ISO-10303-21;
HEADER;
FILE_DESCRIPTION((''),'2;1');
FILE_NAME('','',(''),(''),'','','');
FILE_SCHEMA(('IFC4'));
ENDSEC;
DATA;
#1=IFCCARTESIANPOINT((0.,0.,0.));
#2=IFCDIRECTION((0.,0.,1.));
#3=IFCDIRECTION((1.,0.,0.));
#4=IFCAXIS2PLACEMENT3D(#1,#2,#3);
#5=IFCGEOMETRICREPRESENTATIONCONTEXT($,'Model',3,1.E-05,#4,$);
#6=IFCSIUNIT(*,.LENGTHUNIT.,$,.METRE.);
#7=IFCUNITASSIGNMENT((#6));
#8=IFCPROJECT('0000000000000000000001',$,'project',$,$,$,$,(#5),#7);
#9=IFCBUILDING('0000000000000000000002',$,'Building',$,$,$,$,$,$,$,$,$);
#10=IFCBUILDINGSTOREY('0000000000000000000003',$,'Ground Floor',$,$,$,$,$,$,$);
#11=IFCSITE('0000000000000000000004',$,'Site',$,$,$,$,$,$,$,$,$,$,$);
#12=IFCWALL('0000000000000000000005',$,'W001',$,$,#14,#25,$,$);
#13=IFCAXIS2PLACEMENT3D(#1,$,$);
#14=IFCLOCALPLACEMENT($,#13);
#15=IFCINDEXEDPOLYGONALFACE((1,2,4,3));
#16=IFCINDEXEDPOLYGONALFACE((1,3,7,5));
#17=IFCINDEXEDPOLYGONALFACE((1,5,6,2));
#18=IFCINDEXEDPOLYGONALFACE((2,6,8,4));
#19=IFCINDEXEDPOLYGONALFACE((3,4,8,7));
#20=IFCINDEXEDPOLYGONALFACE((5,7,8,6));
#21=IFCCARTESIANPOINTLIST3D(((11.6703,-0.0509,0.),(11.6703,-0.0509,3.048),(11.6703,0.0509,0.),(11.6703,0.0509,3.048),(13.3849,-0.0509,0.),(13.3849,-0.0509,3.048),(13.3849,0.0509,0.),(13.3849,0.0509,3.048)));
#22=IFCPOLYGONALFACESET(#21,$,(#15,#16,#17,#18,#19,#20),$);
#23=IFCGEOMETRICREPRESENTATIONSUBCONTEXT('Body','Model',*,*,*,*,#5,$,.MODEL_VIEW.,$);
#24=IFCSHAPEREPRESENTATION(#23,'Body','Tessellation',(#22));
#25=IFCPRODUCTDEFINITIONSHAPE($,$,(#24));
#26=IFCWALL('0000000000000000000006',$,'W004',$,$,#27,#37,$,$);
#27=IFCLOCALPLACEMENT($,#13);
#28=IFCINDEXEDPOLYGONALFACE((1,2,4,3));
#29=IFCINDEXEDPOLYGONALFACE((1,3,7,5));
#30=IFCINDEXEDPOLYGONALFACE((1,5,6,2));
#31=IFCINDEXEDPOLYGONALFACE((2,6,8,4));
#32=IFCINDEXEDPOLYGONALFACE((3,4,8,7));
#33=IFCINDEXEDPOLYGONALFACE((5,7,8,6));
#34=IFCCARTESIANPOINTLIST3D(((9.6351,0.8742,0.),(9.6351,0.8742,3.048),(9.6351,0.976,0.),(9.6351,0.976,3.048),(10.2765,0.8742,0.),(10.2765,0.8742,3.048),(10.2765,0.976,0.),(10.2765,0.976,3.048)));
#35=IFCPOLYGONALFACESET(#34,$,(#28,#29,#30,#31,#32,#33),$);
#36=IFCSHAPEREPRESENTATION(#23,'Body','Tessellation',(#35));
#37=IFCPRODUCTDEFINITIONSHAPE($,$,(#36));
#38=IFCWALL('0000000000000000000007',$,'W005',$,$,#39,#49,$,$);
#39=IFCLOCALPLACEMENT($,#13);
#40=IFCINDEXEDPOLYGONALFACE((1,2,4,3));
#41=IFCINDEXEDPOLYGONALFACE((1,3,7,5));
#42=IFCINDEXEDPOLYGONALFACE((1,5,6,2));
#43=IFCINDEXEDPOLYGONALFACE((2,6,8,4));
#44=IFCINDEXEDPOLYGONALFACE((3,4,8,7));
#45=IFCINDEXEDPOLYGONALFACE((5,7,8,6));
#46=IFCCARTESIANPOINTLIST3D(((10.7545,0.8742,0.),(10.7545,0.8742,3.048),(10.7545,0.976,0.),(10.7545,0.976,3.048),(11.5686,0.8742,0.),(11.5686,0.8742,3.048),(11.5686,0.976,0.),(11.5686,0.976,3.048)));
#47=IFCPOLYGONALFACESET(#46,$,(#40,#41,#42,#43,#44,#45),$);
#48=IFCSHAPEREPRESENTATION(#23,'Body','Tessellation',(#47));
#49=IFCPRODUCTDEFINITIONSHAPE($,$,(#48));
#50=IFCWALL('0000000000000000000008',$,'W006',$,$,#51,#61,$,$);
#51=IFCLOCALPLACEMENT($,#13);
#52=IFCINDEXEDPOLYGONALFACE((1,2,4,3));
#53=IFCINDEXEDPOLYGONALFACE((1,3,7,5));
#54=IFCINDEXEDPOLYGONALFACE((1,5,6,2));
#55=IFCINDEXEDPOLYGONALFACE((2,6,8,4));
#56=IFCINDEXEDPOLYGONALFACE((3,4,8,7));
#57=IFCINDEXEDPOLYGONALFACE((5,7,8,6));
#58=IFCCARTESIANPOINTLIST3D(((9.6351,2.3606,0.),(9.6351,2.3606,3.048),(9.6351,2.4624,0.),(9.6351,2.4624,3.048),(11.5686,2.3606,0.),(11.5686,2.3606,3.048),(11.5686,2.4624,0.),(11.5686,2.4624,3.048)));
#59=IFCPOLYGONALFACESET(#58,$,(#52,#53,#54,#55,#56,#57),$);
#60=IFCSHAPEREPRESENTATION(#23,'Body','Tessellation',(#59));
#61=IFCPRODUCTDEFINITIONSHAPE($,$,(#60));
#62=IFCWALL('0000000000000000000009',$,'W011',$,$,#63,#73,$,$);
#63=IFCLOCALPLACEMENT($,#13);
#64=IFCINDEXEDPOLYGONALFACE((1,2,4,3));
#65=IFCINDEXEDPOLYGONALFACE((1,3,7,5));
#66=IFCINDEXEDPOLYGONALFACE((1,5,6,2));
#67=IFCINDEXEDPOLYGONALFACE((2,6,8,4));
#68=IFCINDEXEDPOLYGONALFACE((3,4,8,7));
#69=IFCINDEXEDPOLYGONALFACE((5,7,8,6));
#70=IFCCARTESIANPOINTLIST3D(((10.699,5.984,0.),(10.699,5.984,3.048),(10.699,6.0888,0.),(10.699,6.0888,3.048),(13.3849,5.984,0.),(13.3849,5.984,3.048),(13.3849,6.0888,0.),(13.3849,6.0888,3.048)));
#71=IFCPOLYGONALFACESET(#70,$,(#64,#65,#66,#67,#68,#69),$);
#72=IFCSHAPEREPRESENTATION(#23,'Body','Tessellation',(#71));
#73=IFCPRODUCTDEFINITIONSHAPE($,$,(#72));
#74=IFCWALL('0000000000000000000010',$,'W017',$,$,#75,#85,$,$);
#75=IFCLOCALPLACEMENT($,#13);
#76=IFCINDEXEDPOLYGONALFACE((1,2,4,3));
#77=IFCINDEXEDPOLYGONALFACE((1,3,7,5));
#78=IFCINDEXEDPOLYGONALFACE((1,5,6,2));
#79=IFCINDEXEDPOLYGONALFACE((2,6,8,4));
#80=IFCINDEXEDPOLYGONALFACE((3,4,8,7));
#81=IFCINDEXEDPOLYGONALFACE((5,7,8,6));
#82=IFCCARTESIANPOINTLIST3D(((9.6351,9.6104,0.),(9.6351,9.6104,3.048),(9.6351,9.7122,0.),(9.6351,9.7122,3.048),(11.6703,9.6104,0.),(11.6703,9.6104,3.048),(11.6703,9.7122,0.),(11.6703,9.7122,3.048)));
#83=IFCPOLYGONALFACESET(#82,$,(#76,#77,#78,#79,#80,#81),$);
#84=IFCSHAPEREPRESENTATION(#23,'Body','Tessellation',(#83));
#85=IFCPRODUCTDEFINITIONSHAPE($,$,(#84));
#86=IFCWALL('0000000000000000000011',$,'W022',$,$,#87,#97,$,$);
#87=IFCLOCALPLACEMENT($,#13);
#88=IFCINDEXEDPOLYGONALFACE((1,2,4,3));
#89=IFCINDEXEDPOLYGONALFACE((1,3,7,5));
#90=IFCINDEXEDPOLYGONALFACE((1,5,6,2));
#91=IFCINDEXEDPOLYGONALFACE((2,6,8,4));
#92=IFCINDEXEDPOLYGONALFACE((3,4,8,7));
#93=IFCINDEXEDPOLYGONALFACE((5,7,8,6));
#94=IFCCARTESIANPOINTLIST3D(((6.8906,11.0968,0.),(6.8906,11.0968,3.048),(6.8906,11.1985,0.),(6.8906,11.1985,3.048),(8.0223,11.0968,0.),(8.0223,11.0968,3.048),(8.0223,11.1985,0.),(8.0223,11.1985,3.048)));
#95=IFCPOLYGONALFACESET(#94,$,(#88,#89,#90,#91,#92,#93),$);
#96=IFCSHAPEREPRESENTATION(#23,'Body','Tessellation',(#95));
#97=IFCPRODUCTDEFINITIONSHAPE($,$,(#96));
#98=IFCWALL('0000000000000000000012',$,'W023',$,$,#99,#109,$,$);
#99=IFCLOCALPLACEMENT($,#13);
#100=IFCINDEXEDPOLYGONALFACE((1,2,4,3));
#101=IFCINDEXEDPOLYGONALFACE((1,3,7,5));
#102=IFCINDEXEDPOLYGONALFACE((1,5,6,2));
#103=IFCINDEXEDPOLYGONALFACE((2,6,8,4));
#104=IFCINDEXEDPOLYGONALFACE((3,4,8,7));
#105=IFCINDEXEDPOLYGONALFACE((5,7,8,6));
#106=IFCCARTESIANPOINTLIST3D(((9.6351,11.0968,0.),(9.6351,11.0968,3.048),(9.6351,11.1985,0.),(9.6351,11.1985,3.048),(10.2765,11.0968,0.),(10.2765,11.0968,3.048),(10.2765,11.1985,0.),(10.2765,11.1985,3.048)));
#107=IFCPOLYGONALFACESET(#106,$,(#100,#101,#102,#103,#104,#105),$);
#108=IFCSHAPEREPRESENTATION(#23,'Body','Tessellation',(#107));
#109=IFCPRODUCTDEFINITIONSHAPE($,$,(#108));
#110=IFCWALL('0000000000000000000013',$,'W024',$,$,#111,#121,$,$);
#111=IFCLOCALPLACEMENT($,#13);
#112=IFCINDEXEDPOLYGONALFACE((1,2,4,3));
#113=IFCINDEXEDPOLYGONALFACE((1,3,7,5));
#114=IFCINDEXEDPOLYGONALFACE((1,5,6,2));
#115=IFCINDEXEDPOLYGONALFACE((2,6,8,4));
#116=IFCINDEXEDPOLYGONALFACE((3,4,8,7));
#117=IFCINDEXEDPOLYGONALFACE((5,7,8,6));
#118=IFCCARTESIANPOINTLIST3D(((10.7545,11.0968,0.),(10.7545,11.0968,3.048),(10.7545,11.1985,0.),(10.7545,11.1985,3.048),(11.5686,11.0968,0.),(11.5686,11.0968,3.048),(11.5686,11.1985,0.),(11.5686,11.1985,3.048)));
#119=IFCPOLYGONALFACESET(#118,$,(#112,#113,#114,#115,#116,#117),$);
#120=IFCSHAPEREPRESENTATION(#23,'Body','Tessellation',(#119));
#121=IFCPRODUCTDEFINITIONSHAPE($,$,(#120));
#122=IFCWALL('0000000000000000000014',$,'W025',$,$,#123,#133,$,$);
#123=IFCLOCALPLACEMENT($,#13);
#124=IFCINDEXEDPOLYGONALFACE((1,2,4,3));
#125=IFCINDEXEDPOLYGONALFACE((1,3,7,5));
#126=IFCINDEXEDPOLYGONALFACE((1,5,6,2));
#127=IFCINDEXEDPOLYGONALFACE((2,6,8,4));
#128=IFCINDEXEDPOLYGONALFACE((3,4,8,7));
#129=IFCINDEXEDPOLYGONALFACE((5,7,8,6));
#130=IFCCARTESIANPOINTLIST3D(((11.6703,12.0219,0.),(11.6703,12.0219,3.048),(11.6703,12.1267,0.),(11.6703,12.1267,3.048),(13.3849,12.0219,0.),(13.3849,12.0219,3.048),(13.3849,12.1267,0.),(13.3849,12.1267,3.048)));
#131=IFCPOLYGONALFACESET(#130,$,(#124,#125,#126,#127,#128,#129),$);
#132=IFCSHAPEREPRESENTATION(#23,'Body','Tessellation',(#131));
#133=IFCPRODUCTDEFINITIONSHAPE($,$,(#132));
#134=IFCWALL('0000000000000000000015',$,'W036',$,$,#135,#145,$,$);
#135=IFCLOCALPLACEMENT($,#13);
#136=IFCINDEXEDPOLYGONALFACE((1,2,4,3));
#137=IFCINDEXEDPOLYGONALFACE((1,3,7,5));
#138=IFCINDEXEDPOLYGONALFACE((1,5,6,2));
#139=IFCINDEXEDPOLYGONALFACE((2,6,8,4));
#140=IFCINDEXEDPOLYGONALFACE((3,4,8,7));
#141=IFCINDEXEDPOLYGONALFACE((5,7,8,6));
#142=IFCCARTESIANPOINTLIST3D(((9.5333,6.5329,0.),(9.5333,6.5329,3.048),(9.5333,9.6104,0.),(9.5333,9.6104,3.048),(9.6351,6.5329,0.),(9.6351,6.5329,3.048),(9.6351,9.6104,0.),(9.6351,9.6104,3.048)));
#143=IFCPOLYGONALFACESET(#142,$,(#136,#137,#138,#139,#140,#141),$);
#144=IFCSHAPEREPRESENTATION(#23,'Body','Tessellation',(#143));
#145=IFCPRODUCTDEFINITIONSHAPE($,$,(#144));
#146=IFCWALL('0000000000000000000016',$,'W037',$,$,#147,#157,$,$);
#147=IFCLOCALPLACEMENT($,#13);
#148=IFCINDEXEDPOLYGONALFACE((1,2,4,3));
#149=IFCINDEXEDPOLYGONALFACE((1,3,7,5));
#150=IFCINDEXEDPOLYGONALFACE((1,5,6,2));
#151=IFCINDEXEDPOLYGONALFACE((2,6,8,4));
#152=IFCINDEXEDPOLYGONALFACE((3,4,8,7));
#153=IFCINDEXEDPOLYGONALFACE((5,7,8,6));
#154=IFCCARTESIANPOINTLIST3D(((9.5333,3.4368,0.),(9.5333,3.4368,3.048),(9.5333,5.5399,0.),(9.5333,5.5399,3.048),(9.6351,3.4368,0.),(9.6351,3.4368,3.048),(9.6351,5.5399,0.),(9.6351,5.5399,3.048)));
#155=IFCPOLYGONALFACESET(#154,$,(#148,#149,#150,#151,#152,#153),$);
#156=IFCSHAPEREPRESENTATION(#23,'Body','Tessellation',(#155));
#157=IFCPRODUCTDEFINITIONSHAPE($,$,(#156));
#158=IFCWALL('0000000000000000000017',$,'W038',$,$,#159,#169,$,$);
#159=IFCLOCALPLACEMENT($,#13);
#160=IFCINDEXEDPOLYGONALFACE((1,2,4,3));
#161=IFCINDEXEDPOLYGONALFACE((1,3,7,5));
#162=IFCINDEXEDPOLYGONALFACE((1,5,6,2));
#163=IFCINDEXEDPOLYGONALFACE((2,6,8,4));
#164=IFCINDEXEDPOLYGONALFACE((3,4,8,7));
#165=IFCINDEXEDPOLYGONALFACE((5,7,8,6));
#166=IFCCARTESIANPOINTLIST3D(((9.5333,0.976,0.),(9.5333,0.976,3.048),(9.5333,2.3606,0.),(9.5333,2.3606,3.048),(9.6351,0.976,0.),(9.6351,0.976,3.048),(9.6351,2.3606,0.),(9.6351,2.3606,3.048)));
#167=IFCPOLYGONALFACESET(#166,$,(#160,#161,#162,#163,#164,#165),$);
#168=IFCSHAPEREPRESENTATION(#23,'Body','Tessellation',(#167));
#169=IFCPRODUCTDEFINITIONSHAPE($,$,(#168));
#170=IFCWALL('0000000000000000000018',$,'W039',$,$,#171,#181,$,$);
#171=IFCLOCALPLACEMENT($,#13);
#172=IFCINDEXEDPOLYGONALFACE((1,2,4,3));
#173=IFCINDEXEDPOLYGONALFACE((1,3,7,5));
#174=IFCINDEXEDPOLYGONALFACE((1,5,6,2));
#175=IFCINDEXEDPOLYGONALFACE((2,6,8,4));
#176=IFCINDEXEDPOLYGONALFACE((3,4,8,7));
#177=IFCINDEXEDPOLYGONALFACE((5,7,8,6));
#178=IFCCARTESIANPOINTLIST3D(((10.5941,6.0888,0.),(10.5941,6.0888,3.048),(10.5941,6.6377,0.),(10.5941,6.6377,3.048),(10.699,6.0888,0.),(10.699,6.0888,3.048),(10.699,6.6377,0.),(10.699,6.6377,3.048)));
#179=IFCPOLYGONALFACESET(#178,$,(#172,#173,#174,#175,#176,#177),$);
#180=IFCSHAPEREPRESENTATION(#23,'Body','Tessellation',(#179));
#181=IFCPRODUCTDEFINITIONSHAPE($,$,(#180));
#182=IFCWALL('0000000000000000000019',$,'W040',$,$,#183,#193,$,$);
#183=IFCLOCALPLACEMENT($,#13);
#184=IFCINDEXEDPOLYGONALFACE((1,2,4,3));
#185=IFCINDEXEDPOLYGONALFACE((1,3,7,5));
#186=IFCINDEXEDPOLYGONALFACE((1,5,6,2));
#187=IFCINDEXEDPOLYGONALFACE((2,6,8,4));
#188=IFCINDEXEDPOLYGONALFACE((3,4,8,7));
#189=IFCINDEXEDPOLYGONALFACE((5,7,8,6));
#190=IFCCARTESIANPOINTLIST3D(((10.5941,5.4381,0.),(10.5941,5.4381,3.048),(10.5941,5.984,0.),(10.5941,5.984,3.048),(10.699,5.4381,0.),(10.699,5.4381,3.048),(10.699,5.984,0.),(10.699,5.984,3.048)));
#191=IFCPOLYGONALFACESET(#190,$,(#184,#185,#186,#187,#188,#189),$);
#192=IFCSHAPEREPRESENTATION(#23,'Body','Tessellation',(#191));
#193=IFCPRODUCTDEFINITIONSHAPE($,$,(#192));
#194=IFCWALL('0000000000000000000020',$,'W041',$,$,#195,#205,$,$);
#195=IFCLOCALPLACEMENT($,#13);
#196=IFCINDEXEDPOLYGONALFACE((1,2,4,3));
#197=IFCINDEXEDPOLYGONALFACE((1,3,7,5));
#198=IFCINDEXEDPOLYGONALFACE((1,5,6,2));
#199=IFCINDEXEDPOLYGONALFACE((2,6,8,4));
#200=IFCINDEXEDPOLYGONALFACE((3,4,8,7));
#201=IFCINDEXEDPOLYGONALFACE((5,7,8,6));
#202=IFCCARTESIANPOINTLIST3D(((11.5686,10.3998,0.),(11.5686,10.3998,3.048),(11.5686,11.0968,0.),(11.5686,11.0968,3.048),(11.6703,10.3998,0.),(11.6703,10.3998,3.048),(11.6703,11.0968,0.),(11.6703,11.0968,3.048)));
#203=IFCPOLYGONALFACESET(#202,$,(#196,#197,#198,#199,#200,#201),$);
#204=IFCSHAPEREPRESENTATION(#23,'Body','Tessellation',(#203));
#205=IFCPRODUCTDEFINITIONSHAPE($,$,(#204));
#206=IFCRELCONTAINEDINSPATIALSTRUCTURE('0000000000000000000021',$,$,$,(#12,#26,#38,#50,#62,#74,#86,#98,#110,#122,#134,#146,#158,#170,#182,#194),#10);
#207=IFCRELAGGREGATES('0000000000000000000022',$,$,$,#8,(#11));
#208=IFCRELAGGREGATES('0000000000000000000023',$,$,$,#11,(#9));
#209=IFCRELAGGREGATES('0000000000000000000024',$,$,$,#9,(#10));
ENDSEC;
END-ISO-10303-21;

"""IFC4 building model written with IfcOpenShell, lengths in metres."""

from ifc_helpers import new_model, si_unit, frame, origin_with_axes, place, context, subcontext, project, spatial, line, indexed_curve, outline, extrude, element, save


model = new_model("IFC4")

# Units and contexts
model_context = context("Model", 3, precision=1e-05, world=origin_with_axes())
body_context = subcontext(model_context, "Body", "Model", "MODEL_VIEW")
ifc_project = project(units=[si_unit("LENGTHUNIT", "METRE")], contexts=[model_context])

# Site, building, storey
site = spatial("IfcSite", under=ifc_project, Name="Site")
building = spatial("IfcBuilding", under=site, Name="Building")
storey = spatial("IfcBuildingStorey", under=building, Name="Ground Floor")

# Walls
wall_1_placement = place(None, frame((11.6703, 0.0, 0.0), z_axis=(0.0, 0.0, 1.0), x_axis=(1.0, 0.0, 0.0)))
element("IfcWall", 1, at=wall_1_placement, inside=storey, Name="W001", context=body_context, shape_type="SweptSolid", body=[
    extrude(outline(indexed_curve([(0.0, -0.0509), (1.7145, -0.0509), (1.7145, 0.0509), (0.0, 0.0509)], segments=[line(1, 2, 3, 4, 1)])), origin_with_axes(), (0.0, 0.0, 1.0), 3.048),
])
wall_2_placement = place(None, frame((9.6351, 0.9251, 0.0), z_axis=(0.0, 0.0, 1.0), x_axis=(1.0, 0.0, 0.0)))
element("IfcWall", 2, at=wall_2_placement, inside=storey, Name="W004", context=body_context, shape_type="SweptSolid", body=[
    extrude(outline(indexed_curve([(0.0, -0.0509), (0.6414, -0.0509), (0.6414, 0.0509), (0.0, 0.0509)], segments=[line(1, 2, 3, 4, 1)])), origin_with_axes(), (0.0, 0.0, 1.0), 3.048),
])
wall_3_placement = place(None, frame((10.7545, 0.9251, 0.0), z_axis=(0.0, 0.0, 1.0), x_axis=(1.0, 0.0, 0.0)))
element("IfcWall", 3, at=wall_3_placement, inside=storey, Name="W005", context=body_context, shape_type="SweptSolid", body=[
    extrude(outline(indexed_curve([(0.0, -0.0509), (0.8141, -0.0509), (0.8141, 0.0509), (0.0, 0.0509)], segments=[line(1, 2, 3, 4, 1)])), origin_with_axes(), (0.0, 0.0, 1.0), 3.048),
])
wall_4_placement = place(None, frame((9.6351, 2.4115, 0.0), z_axis=(0.0, 0.0, 1.0), x_axis=(1.0, 0.0, 0.0)))
element("IfcWall", 4, at=wall_4_placement, inside=storey, Name="W006", context=body_context, shape_type="SweptSolid", body=[
    extrude(outline(indexed_curve([(0.0, -0.0509), (1.9335, -0.0509), (1.9335, 0.0509), (0.0, 0.0509)], segments=[line(1, 2, 3, 4, 1)])), origin_with_axes(), (0.0, 0.0, 1.0), 3.048),
])
for number, where, z_axis, x_axis, name in (
    (5, (10.699, 6.0364, 0.0), (0.0, 0.0, 1.0), (1.0, 0.0, 0.0), "W011"),
):
    element("IfcWall", number, at=place(None, frame(where, z_axis=z_axis, x_axis=x_axis)), inside=storey, Name=name, context=body_context, shape_type="SweptSolid", body=[
        extrude(outline(indexed_curve([(0.0, -0.0524), (2.6859, -0.0524), (2.6859, 0.0524), (0.0, 0.0524)], segments=[line(1, 2, 3, 4, 1)])), origin_with_axes(), (0.0, 0.0, 1.0), 3.048),
    ])
wall_5_placement = place(None, frame((9.6351, 9.6613, 0.0), z_axis=(0.0, 0.0, 1.0), x_axis=(1.0, 0.0, 0.0)))
element("IfcWall", 6, at=wall_5_placement, inside=storey, Name="W017", context=body_context, shape_type="SweptSolid", body=[
    extrude(outline(indexed_curve([(0.0, -0.0509), (2.0353, -0.0509), (2.0353, 0.0509), (0.0, 0.0509)], segments=[line(1, 2, 3, 4, 1)])), origin_with_axes(), (0.0, 0.0, 1.0), 3.048),
])
wall_6_placement = place(None, frame((6.8906, 11.1476, 0.0), z_axis=(0.0, 0.0, 1.0), x_axis=(1.0, 0.0, 0.0)))
element("IfcWall", 7, at=wall_6_placement, inside=storey, Name="W022", context=body_context, shape_type="SweptSolid", body=[
    extrude(outline(indexed_curve([(0.0, -0.0509), (1.1317, -0.0509), (1.1317, 0.0509), (0.0, 0.0509)], segments=[line(1, 2, 3, 4, 1)])), origin_with_axes(), (0.0, 0.0, 1.0), 3.048),
])
wall_7_placement = place(None, frame((9.6351, 11.1476, 0.0), z_axis=(0.0, 0.0, 1.0), x_axis=(1.0, 0.0, 0.0)))
element("IfcWall", 8, at=wall_7_placement, inside=storey, Name="W023", context=body_context, shape_type="SweptSolid", body=[
    extrude(outline(indexed_curve([(0.0, -0.0509), (0.6414, -0.0509), (0.6414, 0.0509), (0.0, 0.0509)], segments=[line(1, 2, 3, 4, 1)])), origin_with_axes(), (0.0, 0.0, 1.0), 3.048),
])
wall_8_placement = place(None, frame((10.7545, 11.1476, 0.0), z_axis=(0.0, 0.0, 1.0), x_axis=(1.0, 0.0, 0.0)))
element("IfcWall", 9, at=wall_8_placement, inside=storey, Name="W024", context=body_context, shape_type="SweptSolid", body=[
    extrude(outline(indexed_curve([(0.0, -0.0509), (0.8141, -0.0509), (0.8141, 0.0509), (0.0, 0.0509)], segments=[line(1, 2, 3, 4, 1)])), origin_with_axes(), (0.0, 0.0, 1.0), 3.048),
])
wall_9_placement = place(None, frame((11.6703, 12.0743, 0.0), z_axis=(0.0, 0.0, 1.0), x_axis=(1.0, 0.0, 0.0)))
element("IfcWall", 10, at=wall_9_placement, inside=storey, Name="W025", context=body_context, shape_type="SweptSolid", body=[
    extrude(outline(indexed_curve([(0.0, -0.0524), (1.7145, -0.0524), (1.7145, 0.0524), (0.0, 0.0524)], segments=[line(1, 2, 3, 4, 1)])), origin_with_axes(), (0.0, 0.0, 1.0), 3.048),
])
wall_10_placement = place(None, frame((9.5842, 6.5329, 0.0), z_axis=(0.0, 0.0, 1.0), x_axis=(0.0, 1.0, 0.0)))
element("IfcWall", 11, at=wall_10_placement, inside=storey, Name="W036", context=body_context, shape_type="SweptSolid", body=[
    extrude(outline(indexed_curve([(0.0, -0.0509), (3.0776, -0.0509), (3.0776, 0.0509), (0.0, 0.0509)], segments=[line(1, 2, 3, 4, 1)])), origin_with_axes(), (0.0, 0.0, 1.0), 3.048),
])
wall_11_placement = place(None, frame((9.5842, 3.4368, 0.0), z_axis=(0.0, 0.0, 1.0), x_axis=(0.0, 1.0, 0.0)))
element("IfcWall", 12, at=wall_11_placement, inside=storey, Name="W037", context=body_context, shape_type="SweptSolid", body=[
    extrude(outline(indexed_curve([(0.0, -0.0509), (2.1031, -0.0509), (2.1031, 0.0509), (0.0, 0.0509)], segments=[line(1, 2, 3, 4, 1)])), origin_with_axes(), (0.0, 0.0, 1.0), 3.048),
])
wall_12_placement = place(None, frame((9.5842, 0.976, 0.0), z_axis=(0.0, 0.0, 1.0), x_axis=(0.0, 1.0, 0.0)))
element("IfcWall", 13, at=wall_12_placement, inside=storey, Name="W038", context=body_context, shape_type="SweptSolid", body=[
    extrude(outline(indexed_curve([(0.0, -0.0509), (1.3846, -0.0509), (1.3846, 0.0509), (0.0, 0.0509)], segments=[line(1, 2, 3, 4, 1)])), origin_with_axes(), (0.0, 0.0, 1.0), 3.048),
])
wall_13_placement = place(None, frame((10.6465, 6.0888, 0.0), z_axis=(0.0, 0.0, 1.0), x_axis=(0.0, 1.0, 0.0)))
element("IfcWall", 14, at=wall_13_placement, inside=storey, Name="W039", context=body_context, shape_type="SweptSolid", body=[
    extrude(outline(indexed_curve([(0.0, -0.0524), (0.5489, -0.0524), (0.5489, 0.0524), (0.0, 0.0524)], segments=[line(1, 2, 3, 4, 1)])), origin_with_axes(), (0.0, 0.0, 1.0), 3.048),
])
wall_14_placement = place(None, frame((10.6465, 5.4381, 0.0), z_axis=(0.0, 0.0, 1.0), x_axis=(0.0, 1.0, 0.0)))
element("IfcWall", 15, at=wall_14_placement, inside=storey, Name="W040", context=body_context, shape_type="SweptSolid", body=[
    extrude(outline(indexed_curve([(0.0, -0.0524), (0.5458, -0.0524), (0.5458, 0.0524), (0.0, 0.0524)], segments=[line(1, 2, 3, 4, 1)])), origin_with_axes(), (0.0, 0.0, 1.0), 3.048),
])
wall_15_placement = place(None, frame((11.6195, 10.3998, 0.0), z_axis=(0.0, 0.0, 1.0), x_axis=(0.0, 1.0, 0.0)))
element("IfcWall", 16, at=wall_15_placement, inside=storey, Name="W041", context=body_context, shape_type="SweptSolid", body=[
    extrude(outline(indexed_curve([(0.0, -0.0509), (0.6969, -0.0509), (0.6969, 0.0509), (0.0, 0.0509)], segments=[line(1, 2, 3, 4, 1)])), origin_with_axes(), (0.0, 0.0, 1.0), 3.048),
])

save(model, "model.ifc")
